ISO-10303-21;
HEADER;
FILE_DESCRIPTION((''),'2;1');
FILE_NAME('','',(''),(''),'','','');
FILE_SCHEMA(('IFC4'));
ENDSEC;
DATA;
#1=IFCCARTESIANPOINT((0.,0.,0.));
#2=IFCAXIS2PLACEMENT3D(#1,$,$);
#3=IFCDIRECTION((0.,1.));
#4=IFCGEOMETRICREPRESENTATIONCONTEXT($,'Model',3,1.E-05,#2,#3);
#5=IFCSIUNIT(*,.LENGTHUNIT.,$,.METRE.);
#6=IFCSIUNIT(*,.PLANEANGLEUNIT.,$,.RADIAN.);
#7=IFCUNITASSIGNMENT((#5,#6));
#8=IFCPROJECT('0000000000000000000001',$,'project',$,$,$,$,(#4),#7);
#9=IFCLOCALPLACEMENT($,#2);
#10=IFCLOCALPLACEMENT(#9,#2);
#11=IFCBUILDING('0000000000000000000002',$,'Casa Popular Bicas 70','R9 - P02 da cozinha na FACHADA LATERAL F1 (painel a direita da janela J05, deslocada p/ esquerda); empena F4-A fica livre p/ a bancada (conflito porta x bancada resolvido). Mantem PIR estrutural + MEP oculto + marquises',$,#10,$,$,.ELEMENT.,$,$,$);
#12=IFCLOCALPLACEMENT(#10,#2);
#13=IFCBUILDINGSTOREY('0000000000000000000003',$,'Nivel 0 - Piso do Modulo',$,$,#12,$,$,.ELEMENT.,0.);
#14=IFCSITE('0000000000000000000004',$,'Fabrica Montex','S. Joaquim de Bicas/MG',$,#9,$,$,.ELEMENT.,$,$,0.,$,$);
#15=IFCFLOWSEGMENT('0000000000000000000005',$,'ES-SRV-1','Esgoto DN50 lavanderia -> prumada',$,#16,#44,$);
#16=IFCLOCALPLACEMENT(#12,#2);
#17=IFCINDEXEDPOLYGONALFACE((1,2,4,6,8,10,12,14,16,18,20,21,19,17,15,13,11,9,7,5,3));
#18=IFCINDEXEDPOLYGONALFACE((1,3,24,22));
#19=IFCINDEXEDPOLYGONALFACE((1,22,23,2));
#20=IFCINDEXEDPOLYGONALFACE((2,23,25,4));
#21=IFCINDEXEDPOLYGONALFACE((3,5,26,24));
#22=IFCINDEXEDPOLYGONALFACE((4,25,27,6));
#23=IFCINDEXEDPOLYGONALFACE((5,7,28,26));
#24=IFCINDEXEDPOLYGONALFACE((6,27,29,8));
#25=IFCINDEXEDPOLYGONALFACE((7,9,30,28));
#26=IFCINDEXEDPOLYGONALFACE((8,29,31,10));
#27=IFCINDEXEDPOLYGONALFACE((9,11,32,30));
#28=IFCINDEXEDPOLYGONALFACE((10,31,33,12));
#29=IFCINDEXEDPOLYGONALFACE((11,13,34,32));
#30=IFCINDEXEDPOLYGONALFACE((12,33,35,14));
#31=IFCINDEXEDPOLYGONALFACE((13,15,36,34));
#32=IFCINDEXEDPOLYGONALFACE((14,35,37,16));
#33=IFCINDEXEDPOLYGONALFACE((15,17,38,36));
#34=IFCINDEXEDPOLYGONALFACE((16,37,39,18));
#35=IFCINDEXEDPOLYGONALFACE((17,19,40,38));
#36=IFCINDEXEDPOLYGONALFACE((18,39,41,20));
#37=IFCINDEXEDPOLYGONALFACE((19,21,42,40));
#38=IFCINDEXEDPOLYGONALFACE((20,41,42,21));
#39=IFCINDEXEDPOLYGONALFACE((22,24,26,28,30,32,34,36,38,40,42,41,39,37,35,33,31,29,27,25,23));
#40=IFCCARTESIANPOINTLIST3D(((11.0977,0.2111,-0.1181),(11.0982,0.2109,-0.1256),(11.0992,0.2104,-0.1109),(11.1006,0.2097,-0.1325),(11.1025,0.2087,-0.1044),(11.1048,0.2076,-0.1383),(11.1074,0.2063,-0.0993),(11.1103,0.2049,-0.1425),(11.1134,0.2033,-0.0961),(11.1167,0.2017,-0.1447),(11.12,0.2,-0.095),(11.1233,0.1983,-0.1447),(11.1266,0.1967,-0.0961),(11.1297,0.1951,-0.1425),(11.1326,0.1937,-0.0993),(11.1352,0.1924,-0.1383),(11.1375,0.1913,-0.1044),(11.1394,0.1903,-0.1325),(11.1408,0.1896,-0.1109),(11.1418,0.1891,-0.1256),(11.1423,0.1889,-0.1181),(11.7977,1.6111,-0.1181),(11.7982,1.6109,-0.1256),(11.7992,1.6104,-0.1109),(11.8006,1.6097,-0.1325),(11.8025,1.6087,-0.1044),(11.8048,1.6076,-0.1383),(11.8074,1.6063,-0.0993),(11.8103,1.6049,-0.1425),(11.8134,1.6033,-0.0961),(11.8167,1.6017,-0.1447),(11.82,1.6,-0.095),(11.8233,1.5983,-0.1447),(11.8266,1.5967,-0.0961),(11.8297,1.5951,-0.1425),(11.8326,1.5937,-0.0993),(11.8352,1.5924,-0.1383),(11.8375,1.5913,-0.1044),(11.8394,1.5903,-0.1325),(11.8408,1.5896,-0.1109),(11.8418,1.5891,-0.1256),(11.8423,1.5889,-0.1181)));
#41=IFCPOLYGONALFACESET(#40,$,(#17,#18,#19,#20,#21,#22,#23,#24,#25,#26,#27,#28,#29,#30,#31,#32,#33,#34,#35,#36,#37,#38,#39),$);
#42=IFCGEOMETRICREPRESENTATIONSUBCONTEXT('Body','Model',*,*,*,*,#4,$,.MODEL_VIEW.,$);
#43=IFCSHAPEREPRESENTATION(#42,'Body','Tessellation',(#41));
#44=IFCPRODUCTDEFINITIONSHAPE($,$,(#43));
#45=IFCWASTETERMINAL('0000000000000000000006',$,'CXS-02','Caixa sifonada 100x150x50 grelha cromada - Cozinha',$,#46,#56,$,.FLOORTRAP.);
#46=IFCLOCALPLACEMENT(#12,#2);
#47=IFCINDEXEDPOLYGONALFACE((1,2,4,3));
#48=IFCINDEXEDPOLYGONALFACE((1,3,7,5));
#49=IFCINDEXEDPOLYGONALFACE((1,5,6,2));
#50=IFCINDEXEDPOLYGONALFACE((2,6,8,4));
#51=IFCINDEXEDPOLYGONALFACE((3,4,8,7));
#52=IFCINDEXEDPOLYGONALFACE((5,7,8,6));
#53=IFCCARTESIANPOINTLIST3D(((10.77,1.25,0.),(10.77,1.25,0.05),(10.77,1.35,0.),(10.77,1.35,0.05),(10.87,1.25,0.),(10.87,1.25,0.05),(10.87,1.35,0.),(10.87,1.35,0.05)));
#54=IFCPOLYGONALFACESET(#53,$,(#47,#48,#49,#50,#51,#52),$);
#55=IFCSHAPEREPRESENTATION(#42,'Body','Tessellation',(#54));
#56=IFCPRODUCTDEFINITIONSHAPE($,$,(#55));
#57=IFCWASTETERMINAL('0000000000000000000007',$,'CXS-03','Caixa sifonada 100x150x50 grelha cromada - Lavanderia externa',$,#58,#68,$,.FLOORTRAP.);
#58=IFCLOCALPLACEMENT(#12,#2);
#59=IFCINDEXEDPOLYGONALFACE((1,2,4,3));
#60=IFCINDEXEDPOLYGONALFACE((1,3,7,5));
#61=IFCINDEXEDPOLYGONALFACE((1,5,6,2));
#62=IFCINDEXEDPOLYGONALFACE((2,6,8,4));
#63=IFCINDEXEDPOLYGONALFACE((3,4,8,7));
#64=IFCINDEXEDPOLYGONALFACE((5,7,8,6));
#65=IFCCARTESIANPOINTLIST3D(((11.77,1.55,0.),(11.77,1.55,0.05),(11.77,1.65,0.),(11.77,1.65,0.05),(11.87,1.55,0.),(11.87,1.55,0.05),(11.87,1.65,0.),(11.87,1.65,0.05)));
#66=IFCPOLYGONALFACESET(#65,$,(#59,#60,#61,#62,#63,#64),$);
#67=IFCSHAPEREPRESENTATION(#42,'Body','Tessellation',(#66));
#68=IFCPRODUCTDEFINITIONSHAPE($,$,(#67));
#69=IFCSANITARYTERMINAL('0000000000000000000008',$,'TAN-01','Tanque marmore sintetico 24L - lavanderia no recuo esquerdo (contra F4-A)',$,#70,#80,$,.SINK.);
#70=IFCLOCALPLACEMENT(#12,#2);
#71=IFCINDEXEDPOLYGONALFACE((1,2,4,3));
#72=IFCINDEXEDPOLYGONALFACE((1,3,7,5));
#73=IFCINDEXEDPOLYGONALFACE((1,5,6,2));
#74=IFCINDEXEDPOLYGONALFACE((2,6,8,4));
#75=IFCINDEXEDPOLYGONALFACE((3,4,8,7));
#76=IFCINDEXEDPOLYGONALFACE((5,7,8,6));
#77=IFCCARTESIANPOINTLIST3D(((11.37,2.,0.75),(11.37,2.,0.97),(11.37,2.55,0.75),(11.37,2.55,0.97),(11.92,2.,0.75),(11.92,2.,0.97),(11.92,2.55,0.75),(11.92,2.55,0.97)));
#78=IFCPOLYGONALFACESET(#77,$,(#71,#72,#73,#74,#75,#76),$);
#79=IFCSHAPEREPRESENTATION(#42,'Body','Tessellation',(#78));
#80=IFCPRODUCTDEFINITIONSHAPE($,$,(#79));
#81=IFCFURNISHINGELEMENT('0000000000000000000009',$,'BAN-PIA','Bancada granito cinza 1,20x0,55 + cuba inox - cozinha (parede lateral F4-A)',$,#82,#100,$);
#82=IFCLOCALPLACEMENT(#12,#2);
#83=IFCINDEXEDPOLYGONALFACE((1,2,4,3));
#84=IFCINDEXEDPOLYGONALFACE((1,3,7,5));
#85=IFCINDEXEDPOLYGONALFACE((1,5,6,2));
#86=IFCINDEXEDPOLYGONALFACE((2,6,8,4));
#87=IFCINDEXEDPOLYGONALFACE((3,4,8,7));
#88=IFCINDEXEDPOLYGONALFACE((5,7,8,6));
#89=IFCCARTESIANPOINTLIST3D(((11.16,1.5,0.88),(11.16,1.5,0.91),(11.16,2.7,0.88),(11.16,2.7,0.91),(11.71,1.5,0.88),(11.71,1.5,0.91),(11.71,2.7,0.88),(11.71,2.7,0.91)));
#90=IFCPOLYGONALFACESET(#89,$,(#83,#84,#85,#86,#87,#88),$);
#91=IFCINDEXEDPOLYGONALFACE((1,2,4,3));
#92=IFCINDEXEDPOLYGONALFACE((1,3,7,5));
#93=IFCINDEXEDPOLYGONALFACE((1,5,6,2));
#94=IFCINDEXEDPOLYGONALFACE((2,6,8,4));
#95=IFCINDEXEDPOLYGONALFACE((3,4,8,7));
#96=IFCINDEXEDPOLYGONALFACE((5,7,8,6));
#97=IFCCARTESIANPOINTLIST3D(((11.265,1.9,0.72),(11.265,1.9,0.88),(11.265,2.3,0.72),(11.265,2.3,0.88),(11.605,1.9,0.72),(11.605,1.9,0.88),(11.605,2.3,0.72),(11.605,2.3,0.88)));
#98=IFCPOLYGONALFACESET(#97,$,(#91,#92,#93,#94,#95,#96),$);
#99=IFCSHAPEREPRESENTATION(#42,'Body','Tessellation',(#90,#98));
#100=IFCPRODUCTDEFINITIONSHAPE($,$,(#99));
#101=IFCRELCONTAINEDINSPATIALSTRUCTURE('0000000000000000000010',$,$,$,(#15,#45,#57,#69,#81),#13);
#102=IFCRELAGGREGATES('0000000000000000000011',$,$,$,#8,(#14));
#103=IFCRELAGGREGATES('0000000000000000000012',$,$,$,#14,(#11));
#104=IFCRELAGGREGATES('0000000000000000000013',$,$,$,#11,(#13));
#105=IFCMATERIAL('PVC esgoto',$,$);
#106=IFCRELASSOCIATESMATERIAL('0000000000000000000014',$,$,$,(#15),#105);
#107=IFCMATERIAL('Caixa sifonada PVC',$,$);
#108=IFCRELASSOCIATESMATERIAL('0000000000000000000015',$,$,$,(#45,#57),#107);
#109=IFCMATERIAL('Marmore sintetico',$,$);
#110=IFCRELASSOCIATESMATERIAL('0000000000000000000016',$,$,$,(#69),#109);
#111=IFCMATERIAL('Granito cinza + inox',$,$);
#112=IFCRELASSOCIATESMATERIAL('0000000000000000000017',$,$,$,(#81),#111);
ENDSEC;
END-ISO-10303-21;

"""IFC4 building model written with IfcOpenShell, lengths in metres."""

from ifc_helpers import new_model, si_unit, direction, frame, frame_2d, origin, origin_2d, place, context, subcontext, project, spatial, rectangle, circle, extrude, material, element, save


model = new_model("IFC4")

# Units and contexts
model_context = context("Model", 3, precision=1e-05, world=origin(), true_north=direction((0.0, 1.0)))
body_context = subcontext(model_context, "Body", "Model", "MODEL_VIEW")
ifc_project = project(units=[si_unit("LENGTHUNIT", "METRE"), si_unit("PLANEANGLEUNIT", "RADIAN")], contexts=[model_context])

# Site, building, storey
site_placement = place(None, origin())
site = spatial("IfcSite", under=ifc_project, at=site_placement, Name="Fabrica Montex", Description="S. Joaquim de Bicas/MG", CompositionType="ELEMENT", RefElevation=0.0)
building_placement = place(site_placement, origin())
building = spatial("IfcBuilding", under=site, at=building_placement, Name="Casa Popular Bicas 70", Description="R9 - P02 da cozinha na FACHADA LATERAL F1 (painel a direita da janela J05, deslocada p/ esquerda); empena F4-A fica livre p/ a bancada (conflito porta x bancada resolvido). Mantem PIR estrutural + MEP oculto + marquises", CompositionType="ELEMENT")
storey_placement = place(building_placement, origin())
storey = spatial("IfcBuildingStorey", under=building, at=storey_placement, Name="Nivel 0 - Piso do Modulo", CompositionType="ELEMENT", Elevation=0.0)

# Flow segment
ifc_material_1 = material(Name="PVC esgoto")
flow_segment_1_placement = place(None, frame((11.82, 1.6, -0.12), z_axis=(-0.447214, -0.894427, 0.0), x_axis=(0.0, 0.0, 1.0)))
element("IfcFlowSegment", 1, at=flow_segment_1_placement, inside=storey, material=ifc_material_1, Name="ES-SRV-1", Description="Esgoto DN50 lavanderia -> prumada", context=body_context, shape_type="SweptSolid", body=[
    extrude(circle(Radius=0.025, at=origin_2d()), origin(), (0.0, 0.0, 1.0), 1.5652),
])

# Waste terminals
ifc_material_2 = material(Name="Caixa sifonada PVC")
for number, where, z_axis, x_axis, name, description in (
    (2, (10.87, 1.35, 0.0), (0.0, 0.0, 1.0), (-1.0, 0.0, 0.0), "CXS-02", "Caixa sifonada 100x150x50 grelha cromada - Cozinha"),
    (3, (11.87, 1.65, 0.0), (0.0, 0.0, 1.0), (-1.0, 0.0, 0.0), "CXS-03", "Caixa sifonada 100x150x50 grelha cromada - Lavanderia externa"),
):
    element("IfcWasteTerminal", number, at=place(None, frame(where, z_axis=z_axis, x_axis=x_axis)), inside=storey, material=ifc_material_2, Name=name, Description=description, PredefinedType="FLOORTRAP", context=body_context, shape_type="SweptSolid", body=[
        extrude(rectangle(XDim=0.1, YDim=0.1, at=frame_2d((0.05, 0.05))), origin(), (0.0, 0.0, 1.0), 0.05),
    ])

# Sanitary terminal
ifc_material_3 = material(Name="Marmore sintetico")
sanitary_terminal_placement = place(None, frame((11.92, 2.55, 0.75), z_axis=(0.0, 0.0, 1.0), x_axis=(-1.0, 0.0, 0.0)))
element("IfcSanitaryTerminal", 4, at=sanitary_terminal_placement, inside=storey, material=ifc_material_3, Name="TAN-01", Description="Tanque marmore sintetico 24L - lavanderia no recuo esquerdo (contra F4-A)", PredefinedType="SINK", context=body_context, shape_type="SweptSolid", body=[
    extrude(rectangle(XDim=0.55, YDim=0.55, at=frame_2d((0.275, 0.275))), origin(), (0.0, 0.0, 1.0), 0.22),
])

# Furnishing element
ifc_material_4 = material(Name="Granito cinza + inox")
furnishing_placement = place(None, frame((11.16, 2.7, 0.88), z_axis=(0.0, 0.0, 1.0), x_axis=(0.0, -1.0, 0.0)))
element("IfcFurnishingElement", 5, at=furnishing_placement, inside=storey, material=ifc_material_4, Name="BAN-PIA", Description="Bancada granito cinza 1,20x0,55 + cuba inox - cozinha (parede lateral F4-A)", context=body_context, shape_type="SweptSolid", body=[
    extrude(rectangle(XDim=1.2, YDim=0.55, at=frame_2d((0.6, 0.275))), origin(), (0.0, 0.0, 1.0), 0.03),
    extrude(rectangle(XDim=0.4, YDim=0.34, at=frame_2d((0.6, 0.275))), frame((0.0, 0.0, -0.16)), (0.0, 0.0, 1.0), 0.16),
])

save(model, "model.ifc")
